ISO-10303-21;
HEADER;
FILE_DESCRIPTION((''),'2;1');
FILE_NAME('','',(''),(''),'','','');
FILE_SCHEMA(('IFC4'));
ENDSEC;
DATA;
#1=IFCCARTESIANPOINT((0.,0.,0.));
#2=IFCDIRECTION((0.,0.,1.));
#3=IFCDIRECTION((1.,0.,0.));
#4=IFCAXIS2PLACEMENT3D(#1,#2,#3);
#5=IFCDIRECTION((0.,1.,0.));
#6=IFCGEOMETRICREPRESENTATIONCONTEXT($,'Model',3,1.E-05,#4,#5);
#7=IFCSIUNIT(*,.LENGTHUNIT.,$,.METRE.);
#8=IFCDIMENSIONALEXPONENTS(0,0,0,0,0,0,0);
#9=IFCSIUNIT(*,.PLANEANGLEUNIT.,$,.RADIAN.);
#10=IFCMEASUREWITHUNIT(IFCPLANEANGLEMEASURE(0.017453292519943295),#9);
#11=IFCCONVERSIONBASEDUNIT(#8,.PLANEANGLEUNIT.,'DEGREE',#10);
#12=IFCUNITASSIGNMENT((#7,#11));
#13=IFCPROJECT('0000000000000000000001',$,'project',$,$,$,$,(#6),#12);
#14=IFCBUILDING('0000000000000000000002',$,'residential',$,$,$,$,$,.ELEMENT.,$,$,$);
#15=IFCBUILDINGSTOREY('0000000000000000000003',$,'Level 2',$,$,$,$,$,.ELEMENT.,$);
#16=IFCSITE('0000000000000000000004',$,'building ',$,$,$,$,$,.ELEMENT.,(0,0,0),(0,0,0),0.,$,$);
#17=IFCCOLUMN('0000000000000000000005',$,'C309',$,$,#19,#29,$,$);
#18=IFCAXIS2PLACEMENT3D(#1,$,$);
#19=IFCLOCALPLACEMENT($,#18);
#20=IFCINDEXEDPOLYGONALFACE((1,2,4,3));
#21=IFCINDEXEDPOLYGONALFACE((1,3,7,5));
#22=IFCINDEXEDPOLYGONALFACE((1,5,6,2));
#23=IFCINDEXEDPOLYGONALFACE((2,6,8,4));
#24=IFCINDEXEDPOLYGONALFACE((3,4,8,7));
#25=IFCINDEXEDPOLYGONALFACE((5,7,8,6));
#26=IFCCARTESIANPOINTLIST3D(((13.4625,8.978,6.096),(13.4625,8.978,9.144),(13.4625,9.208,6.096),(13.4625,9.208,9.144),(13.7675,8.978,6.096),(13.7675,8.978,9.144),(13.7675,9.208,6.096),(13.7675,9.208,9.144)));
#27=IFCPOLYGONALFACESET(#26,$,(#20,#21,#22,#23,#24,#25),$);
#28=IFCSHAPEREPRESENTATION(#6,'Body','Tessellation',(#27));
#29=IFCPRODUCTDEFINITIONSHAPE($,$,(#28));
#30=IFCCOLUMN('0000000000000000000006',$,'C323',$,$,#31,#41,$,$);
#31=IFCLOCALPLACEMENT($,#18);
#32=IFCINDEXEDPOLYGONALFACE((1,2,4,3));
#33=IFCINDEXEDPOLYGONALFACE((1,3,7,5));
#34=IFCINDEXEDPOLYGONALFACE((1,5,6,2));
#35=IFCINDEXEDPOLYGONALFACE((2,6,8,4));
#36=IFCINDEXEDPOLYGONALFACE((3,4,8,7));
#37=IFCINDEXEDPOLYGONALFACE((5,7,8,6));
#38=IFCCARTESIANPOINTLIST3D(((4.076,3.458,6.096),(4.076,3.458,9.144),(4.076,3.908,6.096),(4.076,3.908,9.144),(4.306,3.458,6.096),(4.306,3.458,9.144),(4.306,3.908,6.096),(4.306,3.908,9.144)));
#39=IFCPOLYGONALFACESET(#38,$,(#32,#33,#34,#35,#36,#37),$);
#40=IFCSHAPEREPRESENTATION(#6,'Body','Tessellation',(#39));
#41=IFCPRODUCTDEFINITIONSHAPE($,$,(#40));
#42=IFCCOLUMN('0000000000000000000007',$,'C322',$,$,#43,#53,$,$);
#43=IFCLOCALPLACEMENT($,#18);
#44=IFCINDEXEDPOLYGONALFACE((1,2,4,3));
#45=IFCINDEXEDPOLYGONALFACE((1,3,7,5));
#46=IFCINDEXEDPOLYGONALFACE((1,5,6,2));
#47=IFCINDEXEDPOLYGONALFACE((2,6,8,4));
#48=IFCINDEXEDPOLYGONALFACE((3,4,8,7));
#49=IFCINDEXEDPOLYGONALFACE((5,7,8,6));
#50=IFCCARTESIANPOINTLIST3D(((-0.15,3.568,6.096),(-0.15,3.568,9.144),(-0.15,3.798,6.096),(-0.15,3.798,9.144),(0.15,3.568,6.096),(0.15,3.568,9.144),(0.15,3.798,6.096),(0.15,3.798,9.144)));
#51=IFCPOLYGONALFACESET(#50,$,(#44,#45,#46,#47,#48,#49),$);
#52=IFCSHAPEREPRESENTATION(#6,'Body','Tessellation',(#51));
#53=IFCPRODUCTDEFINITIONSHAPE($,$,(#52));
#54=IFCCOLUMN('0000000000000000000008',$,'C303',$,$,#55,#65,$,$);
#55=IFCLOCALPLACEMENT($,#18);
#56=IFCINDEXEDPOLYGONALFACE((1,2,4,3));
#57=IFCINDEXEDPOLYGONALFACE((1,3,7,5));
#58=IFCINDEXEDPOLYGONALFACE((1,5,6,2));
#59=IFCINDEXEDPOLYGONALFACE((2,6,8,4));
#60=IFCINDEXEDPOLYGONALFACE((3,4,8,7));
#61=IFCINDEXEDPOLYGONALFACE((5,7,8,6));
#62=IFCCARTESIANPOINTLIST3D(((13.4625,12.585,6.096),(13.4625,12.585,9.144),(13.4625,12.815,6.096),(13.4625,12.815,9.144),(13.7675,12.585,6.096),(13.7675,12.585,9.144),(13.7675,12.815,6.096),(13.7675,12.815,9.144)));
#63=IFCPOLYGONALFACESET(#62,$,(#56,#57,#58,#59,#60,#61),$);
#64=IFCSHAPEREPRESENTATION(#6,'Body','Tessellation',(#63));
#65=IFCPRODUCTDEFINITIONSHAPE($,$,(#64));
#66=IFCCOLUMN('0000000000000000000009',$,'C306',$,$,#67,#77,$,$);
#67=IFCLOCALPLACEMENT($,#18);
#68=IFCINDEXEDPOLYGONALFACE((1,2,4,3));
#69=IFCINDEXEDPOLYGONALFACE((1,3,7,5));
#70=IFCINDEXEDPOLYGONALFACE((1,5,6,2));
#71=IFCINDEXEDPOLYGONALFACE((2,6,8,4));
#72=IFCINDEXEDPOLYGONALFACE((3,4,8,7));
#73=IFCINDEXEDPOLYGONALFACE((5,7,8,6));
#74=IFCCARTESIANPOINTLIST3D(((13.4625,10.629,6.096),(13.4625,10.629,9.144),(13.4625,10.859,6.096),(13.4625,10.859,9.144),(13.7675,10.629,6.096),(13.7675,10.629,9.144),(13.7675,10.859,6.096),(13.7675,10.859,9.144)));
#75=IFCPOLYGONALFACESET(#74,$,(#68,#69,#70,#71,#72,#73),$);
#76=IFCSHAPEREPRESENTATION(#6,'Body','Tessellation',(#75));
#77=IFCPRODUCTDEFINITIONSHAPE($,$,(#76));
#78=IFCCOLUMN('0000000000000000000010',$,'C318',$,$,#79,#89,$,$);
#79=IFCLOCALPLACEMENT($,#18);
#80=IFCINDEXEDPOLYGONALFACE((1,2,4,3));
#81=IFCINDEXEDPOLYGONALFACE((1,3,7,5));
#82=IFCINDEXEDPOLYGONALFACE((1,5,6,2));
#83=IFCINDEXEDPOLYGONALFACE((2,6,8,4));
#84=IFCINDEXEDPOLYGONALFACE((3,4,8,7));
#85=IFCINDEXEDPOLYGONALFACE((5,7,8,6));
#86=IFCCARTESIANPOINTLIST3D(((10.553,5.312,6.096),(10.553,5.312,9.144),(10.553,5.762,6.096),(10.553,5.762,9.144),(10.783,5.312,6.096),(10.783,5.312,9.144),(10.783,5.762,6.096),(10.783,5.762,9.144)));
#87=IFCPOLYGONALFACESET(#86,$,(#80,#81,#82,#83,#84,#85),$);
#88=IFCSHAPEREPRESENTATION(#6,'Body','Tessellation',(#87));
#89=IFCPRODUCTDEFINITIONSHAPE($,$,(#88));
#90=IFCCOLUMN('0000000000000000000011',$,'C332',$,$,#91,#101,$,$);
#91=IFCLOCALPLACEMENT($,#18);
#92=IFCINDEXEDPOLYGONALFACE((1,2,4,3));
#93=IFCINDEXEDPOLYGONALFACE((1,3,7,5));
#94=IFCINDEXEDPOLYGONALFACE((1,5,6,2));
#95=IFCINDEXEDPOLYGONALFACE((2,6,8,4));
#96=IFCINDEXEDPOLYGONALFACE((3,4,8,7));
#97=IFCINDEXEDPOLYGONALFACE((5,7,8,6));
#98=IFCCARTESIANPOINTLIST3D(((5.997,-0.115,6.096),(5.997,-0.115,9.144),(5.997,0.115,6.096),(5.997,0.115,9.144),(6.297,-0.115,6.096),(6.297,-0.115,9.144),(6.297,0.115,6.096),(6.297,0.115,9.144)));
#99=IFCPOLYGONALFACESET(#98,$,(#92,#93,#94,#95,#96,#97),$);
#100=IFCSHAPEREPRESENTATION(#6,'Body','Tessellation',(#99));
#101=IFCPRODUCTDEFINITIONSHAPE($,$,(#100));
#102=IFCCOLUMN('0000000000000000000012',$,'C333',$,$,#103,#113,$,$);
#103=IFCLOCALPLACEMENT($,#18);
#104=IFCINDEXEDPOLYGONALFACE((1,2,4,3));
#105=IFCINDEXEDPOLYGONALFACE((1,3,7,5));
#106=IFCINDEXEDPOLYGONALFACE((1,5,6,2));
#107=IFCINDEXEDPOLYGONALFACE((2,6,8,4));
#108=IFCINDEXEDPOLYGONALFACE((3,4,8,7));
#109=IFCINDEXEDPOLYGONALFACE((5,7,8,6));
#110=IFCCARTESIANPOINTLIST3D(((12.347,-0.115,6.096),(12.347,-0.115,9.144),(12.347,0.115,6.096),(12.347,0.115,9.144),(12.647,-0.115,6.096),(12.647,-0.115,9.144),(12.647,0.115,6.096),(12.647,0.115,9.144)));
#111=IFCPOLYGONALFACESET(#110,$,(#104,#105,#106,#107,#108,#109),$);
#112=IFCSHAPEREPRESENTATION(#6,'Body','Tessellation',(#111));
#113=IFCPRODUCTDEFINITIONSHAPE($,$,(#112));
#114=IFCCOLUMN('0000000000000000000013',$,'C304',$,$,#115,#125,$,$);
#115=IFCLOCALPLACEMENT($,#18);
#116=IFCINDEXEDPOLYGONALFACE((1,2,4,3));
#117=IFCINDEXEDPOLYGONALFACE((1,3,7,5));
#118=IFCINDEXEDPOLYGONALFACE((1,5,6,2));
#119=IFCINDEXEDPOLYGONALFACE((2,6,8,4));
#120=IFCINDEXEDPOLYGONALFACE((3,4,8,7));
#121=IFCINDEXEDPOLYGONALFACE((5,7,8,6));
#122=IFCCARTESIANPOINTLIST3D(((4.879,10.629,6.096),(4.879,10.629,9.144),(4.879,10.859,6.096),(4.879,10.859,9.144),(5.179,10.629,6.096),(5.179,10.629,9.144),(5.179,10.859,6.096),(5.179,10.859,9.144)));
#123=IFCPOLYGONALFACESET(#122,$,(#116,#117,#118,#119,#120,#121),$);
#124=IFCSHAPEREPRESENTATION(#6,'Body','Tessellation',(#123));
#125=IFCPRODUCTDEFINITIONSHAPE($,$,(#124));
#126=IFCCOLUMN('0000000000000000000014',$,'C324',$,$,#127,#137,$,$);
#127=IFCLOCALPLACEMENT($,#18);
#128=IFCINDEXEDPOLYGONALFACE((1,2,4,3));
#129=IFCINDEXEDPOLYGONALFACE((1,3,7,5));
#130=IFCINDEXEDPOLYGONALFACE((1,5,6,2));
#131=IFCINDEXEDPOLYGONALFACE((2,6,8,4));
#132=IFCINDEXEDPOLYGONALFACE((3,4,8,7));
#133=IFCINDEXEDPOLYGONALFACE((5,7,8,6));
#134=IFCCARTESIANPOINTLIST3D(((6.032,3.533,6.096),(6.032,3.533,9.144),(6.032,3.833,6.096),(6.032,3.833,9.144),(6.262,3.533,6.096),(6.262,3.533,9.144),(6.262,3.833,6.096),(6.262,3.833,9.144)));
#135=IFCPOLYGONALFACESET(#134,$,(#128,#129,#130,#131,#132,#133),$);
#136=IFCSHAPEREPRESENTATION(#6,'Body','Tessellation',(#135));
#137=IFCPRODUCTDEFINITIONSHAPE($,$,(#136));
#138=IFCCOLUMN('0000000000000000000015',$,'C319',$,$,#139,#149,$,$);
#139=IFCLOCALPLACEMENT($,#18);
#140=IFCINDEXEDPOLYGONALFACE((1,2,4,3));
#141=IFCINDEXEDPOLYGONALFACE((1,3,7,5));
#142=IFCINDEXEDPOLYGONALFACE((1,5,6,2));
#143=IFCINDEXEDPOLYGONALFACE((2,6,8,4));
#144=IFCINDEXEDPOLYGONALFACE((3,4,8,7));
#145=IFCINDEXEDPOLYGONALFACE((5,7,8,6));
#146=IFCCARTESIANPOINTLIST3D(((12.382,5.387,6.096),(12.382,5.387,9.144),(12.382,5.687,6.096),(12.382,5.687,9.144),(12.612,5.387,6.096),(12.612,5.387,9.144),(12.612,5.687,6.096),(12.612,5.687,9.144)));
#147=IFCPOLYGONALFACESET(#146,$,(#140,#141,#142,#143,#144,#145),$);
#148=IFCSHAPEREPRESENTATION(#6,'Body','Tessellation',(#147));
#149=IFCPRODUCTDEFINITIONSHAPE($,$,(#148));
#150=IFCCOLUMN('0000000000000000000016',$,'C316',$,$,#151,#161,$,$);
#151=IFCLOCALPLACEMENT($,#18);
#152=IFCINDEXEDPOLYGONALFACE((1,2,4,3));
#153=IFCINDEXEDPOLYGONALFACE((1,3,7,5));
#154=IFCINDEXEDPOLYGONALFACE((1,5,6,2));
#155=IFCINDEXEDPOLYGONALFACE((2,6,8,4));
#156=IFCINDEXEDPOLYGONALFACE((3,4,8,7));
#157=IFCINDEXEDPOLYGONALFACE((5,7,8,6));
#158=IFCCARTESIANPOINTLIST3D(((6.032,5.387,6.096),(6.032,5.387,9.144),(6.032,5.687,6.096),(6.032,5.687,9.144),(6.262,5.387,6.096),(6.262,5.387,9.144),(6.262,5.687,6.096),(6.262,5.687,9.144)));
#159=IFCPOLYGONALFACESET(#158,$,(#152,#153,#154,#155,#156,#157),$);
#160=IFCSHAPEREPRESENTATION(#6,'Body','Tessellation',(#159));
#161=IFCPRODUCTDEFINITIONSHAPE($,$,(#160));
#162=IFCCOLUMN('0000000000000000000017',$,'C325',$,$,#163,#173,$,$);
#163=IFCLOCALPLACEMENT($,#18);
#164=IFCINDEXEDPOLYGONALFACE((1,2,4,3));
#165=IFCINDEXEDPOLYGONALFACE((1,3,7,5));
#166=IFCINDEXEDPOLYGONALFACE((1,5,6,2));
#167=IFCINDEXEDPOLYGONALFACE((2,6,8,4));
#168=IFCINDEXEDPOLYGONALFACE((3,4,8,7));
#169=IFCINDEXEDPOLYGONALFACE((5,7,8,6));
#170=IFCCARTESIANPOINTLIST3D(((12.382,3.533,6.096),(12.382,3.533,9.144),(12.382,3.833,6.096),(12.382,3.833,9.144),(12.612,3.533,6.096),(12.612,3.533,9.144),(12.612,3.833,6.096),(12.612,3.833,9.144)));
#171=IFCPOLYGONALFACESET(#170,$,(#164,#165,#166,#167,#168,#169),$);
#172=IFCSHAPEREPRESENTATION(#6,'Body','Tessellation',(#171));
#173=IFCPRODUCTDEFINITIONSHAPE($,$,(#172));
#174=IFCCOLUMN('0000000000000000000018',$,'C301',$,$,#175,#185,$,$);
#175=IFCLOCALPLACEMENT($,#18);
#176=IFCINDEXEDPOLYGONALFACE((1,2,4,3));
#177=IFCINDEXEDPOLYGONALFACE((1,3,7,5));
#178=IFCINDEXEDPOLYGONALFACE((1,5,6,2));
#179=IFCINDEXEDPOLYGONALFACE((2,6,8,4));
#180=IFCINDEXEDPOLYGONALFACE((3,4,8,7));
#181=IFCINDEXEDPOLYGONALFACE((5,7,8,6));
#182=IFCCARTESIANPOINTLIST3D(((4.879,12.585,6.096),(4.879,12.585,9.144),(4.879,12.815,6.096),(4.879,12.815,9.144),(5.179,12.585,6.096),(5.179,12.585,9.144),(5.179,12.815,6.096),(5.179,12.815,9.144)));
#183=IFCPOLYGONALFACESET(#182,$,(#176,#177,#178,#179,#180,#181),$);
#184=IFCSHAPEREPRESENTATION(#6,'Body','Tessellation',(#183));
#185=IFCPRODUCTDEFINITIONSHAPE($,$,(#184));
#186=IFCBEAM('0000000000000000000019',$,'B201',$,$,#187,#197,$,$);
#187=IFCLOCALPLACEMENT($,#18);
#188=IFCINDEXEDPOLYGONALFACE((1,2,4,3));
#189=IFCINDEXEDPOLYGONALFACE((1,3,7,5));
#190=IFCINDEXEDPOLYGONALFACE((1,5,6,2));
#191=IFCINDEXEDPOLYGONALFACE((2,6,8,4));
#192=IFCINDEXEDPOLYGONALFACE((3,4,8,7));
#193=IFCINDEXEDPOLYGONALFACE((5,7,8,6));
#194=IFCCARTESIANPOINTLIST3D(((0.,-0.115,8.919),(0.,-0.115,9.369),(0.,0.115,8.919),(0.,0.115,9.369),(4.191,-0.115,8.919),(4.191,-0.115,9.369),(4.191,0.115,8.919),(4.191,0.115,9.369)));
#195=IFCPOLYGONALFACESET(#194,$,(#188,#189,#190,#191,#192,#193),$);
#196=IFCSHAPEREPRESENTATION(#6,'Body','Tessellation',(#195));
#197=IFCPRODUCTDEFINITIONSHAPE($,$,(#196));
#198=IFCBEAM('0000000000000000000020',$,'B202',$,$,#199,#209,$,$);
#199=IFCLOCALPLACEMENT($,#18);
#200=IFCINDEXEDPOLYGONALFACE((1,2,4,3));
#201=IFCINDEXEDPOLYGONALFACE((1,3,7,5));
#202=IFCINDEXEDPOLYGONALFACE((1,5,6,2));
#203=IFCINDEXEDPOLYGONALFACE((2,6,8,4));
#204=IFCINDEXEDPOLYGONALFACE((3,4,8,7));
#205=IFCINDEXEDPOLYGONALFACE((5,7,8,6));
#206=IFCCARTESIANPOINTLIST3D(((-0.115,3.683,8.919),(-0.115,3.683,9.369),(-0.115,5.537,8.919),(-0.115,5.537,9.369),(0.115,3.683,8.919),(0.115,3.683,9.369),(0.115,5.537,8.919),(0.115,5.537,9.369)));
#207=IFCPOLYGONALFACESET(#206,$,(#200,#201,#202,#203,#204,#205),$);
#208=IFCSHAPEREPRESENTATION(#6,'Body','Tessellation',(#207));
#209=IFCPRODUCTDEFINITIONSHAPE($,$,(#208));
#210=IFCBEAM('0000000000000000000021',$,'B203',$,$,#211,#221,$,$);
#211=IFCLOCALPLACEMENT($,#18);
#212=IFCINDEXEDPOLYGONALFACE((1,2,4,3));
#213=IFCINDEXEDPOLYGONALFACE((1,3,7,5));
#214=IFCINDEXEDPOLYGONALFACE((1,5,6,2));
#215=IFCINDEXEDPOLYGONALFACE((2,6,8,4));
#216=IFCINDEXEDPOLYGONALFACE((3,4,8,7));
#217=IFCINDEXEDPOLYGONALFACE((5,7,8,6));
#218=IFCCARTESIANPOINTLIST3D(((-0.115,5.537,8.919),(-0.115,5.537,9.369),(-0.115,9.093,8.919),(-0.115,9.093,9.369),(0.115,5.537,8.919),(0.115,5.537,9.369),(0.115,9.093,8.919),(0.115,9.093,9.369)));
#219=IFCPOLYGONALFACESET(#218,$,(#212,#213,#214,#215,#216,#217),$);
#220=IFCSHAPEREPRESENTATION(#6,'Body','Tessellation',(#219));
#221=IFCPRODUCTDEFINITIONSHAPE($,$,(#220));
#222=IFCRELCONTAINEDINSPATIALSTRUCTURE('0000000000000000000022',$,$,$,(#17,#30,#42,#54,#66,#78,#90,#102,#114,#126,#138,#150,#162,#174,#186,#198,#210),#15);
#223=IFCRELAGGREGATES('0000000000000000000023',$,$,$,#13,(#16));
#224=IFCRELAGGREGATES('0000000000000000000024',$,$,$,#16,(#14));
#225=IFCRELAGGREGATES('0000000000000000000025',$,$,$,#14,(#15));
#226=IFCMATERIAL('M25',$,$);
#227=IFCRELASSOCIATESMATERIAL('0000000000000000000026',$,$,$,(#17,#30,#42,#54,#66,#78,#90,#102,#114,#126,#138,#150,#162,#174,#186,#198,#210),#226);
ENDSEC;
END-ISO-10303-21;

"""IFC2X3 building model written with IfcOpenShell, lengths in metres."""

from ifc_helpers import new_model, entity, si_unit, converted_unit, direction, frame, frame_2d, origin_with_axes, place, context, project, spatial, rectangle, extrude, material, element, save


model = new_model("IFC2X3")

# Units and contexts
model_context = context("Model", 3, precision=1e-05, world=origin_with_axes(), true_north=direction((0.0, 1.0, 0.0)))
ifc_project = project(units=[si_unit("LENGTHUNIT", "METRE"), converted_unit("PLANEANGLEUNIT", "DEGREE", entity("IfcPlaneAngleMeasure", 0.017453292519943295), si_unit("PLANEANGLEUNIT", "RADIAN"), dimensions=[0, 0, 0, 0, 0, 0, 0])], contexts=[model_context])

# Site, building, storey
site = spatial("IfcSite", under=ifc_project, Name="building ", CompositionType="ELEMENT", RefLatitude=(0, 0, 0), RefLongitude=(0, 0, 0), RefElevation=0.0)
building = spatial("IfcBuilding", under=site, Name="residential", CompositionType="ELEMENT")
storey = spatial("IfcBuildingStorey", under=building, Name="Level 2", CompositionType="ELEMENT")

# Columns
ifc_material = material(Name="M25")
placement = place(None, origin_with_axes())
element("IfcColumn", 1, at=placement, inside=storey, material=ifc_material, Name="C309", context=model_context, shape_type="SweptSolid", body=[
    extrude(rectangle(XDim=0.305, YDim=0.23, at=frame_2d((0.0, 0.0), x_axis=(1.0, 0.0, 0.0))), frame((13.615, 9.093, 6.096), z_axis=(0.0, 0.0, 1.0), x_axis=(1.0, 0.0, 0.0)), (0.0, 0.0, 1.0), 3.048),
])
element("IfcColumn", 2, at=placement, inside=storey, material=ifc_material, Name="C323", context=model_context, shape_type="SweptSolid", body=[
    extrude(rectangle(XDim=0.23, YDim=0.45, at=frame_2d((0.0, 0.0), x_axis=(1.0, 0.0, 0.0))), frame((4.191, 3.683, 6.096), z_axis=(0.0, 0.0, 1.0), x_axis=(1.0, 0.0, 0.0)), (0.0, 0.0, 1.0), 3.048),
])
element("IfcColumn", 3, at=placement, inside=storey, material=ifc_material, Name="C322", context=model_context, shape_type="SweptSolid", body=[
    extrude(rectangle(XDim=0.3, YDim=0.23, at=frame_2d((0.0, 0.0), x_axis=(1.0, 0.0, 0.0))), frame((0.0, 3.683, 6.096), z_axis=(0.0, 0.0, 1.0), x_axis=(1.0, 0.0, 0.0)), (0.0, 0.0, 1.0), 3.048),
])
element("IfcColumn", 4, at=placement, inside=storey, material=ifc_material, Name="C303", context=model_context, shape_type="SweptSolid", body=[
    extrude(rectangle(XDim=0.305, YDim=0.23, at=frame_2d((0.0, 0.0), x_axis=(1.0, 0.0, 0.0))), frame((13.615, 12.7, 6.096), z_axis=(0.0, 0.0, 1.0), x_axis=(1.0, 0.0, 0.0)), (0.0, 0.0, 1.0), 3.048),
])
element("IfcColumn", 5, at=placement, inside=storey, material=ifc_material, Name="C306", context=model_context, shape_type="SweptSolid", body=[
    extrude(rectangle(XDim=0.305, YDim=0.23, at=frame_2d((0.0, 0.0), x_axis=(1.0, 0.0, 0.0))), frame((13.615, 10.744, 6.096), z_axis=(0.0, 0.0, 1.0), x_axis=(1.0, 0.0, 0.0)), (0.0, 0.0, 1.0), 3.048),
])
element("IfcColumn", 6, at=placement, inside=storey, material=ifc_material, Name="C318", context=model_context, shape_type="SweptSolid", body=[
    extrude(rectangle(XDim=0.23, YDim=0.45, at=frame_2d((0.0, 0.0), x_axis=(1.0, 0.0, 0.0))), frame((10.668, 5.537, 6.096), z_axis=(0.0, 0.0, 1.0), x_axis=(1.0, 0.0, 0.0)), (0.0, 0.0, 1.0), 3.048),
])
element("IfcColumn", 7, at=placement, inside=storey, material=ifc_material, Name="C332", context=model_context, shape_type="SweptSolid", body=[
    extrude(rectangle(XDim=0.3, YDim=0.23, at=frame_2d((0.0, 0.0), x_axis=(1.0, 0.0, 0.0))), frame((6.147, 0.0, 6.096), z_axis=(0.0, 0.0, 1.0), x_axis=(1.0, 0.0, 0.0)), (0.0, 0.0, 1.0), 3.048),
])
element("IfcColumn", 8, at=placement, inside=storey, material=ifc_material, Name="C333", context=model_context, shape_type="SweptSolid", body=[
    extrude(rectangle(XDim=0.3, YDim=0.23, at=frame_2d((0.0, 0.0), x_axis=(1.0, 0.0, 0.0))), frame((12.497, 0.0, 6.096), z_axis=(0.0, 0.0, 1.0), x_axis=(1.0, 0.0, 0.0)), (0.0, 0.0, 1.0), 3.048),
])
element("IfcColumn", 9, at=placement, inside=storey, material=ifc_material, Name="C304", context=model_context, shape_type="SweptSolid", body=[
    extrude(rectangle(XDim=0.3, YDim=0.23, at=frame_2d((0.0, 0.0), x_axis=(1.0, 0.0, 0.0))), frame((5.029, 10.744, 6.096), z_axis=(0.0, 0.0, 1.0), x_axis=(1.0, 0.0, 0.0)), (0.0, 0.0, 1.0), 3.048),
])
element("IfcColumn", 10, at=placement, inside=storey, material=ifc_material, Name="C324", context=model_context, shape_type="SweptSolid", body=[
    extrude(rectangle(XDim=0.23, YDim=0.3, at=frame_2d((0.0, 0.0), x_axis=(1.0, 0.0, 0.0))), frame((6.147, 3.683, 6.096), z_axis=(0.0, 0.0, 1.0), x_axis=(1.0, 0.0, 0.0)), (0.0, 0.0, 1.0), 3.048),
])
element("IfcColumn", 11, at=placement, inside=storey, material=ifc_material, Name="C319", context=model_context, shape_type="SweptSolid", body=[
    extrude(rectangle(XDim=0.23, YDim=0.3, at=frame_2d((0.0, 0.0), x_axis=(1.0, 0.0, 0.0))), frame((12.497, 5.537, 6.096), z_axis=(0.0, 0.0, 1.0), x_axis=(1.0, 0.0, 0.0)), (0.0, 0.0, 1.0), 3.048),
])
element("IfcColumn", 12, at=placement, inside=storey, material=ifc_material, Name="C316", context=model_context, shape_type="SweptSolid", body=[
    extrude(rectangle(XDim=0.23, YDim=0.3, at=frame_2d((0.0, 0.0), x_axis=(1.0, 0.0, 0.0))), frame((6.147, 5.537, 6.096), z_axis=(0.0, 0.0, 1.0), x_axis=(1.0, 0.0, 0.0)), (0.0, 0.0, 1.0), 3.048),
])
element("IfcColumn", 13, at=placement, inside=storey, material=ifc_material, Name="C325", context=model_context, shape_type="SweptSolid", body=[
    extrude(rectangle(XDim=0.23, YDim=0.3, at=frame_2d((0.0, 0.0), x_axis=(1.0, 0.0, 0.0))), frame((12.497, 3.683, 6.096), z_axis=(0.0, 0.0, 1.0), x_axis=(1.0, 0.0, 0.0)), (0.0, 0.0, 1.0), 3.048),
])
element("IfcColumn", 14, at=placement, inside=storey, material=ifc_material, Name="C301", context=model_context, shape_type="SweptSolid", body=[
    extrude(rectangle(XDim=0.3, YDim=0.23, at=frame_2d((0.0, 0.0), x_axis=(1.0, 0.0, 0.0))), frame((5.029, 12.7, 6.096), z_axis=(0.0, 0.0, 1.0), x_axis=(1.0, 0.0, 0.0)), (0.0, 0.0, 1.0), 3.048),
])

# Beams
element("IfcBeam", 15, at=placement, inside=storey, material=ifc_material, Name="B201", context=model_context, shape_type="SweptSolid", body=[
    extrude(rectangle(XDim=0.23, YDim=0.45, at=frame_2d((0.0, 0.0), x_axis=(0.0, 1.0, 0.0))), frame((0.0, 0.0, 9.144), z_axis=(1.0, 0.0, 0.0), x_axis=(0.0, 0.0, -1.0)), (0.0, 0.0, 1.0), 4.191),
])
element("IfcBeam", 16, at=placement, inside=storey, material=ifc_material, Name="B202", context=model_context, shape_type="SweptSolid", body=[
    extrude(rectangle(XDim=0.23, YDim=0.45, at=frame_2d((0.0, 0.0), x_axis=(0.0, 1.0, 0.0))), frame((0.0, 3.683, 9.144), z_axis=(0.0, 1.0, 0.0), x_axis=(0.0, 0.0, -1.0)), (0.0, 0.0, 1.0), 1.854),
])
element("IfcBeam", 17, at=placement, inside=storey, material=ifc_material, Name="B203", context=model_context, shape_type="SweptSolid", body=[
    extrude(rectangle(XDim=0.23, YDim=0.45, at=frame_2d((0.0, 0.0), x_axis=(0.0, 1.0, 0.0))), frame((0.0, 5.537, 9.144), z_axis=(0.0, 1.0, 0.0), x_axis=(0.0, 0.0, -1.0)), (0.0, 0.0, 1.0), 3.556),
])

save(model, "model.ifc")
